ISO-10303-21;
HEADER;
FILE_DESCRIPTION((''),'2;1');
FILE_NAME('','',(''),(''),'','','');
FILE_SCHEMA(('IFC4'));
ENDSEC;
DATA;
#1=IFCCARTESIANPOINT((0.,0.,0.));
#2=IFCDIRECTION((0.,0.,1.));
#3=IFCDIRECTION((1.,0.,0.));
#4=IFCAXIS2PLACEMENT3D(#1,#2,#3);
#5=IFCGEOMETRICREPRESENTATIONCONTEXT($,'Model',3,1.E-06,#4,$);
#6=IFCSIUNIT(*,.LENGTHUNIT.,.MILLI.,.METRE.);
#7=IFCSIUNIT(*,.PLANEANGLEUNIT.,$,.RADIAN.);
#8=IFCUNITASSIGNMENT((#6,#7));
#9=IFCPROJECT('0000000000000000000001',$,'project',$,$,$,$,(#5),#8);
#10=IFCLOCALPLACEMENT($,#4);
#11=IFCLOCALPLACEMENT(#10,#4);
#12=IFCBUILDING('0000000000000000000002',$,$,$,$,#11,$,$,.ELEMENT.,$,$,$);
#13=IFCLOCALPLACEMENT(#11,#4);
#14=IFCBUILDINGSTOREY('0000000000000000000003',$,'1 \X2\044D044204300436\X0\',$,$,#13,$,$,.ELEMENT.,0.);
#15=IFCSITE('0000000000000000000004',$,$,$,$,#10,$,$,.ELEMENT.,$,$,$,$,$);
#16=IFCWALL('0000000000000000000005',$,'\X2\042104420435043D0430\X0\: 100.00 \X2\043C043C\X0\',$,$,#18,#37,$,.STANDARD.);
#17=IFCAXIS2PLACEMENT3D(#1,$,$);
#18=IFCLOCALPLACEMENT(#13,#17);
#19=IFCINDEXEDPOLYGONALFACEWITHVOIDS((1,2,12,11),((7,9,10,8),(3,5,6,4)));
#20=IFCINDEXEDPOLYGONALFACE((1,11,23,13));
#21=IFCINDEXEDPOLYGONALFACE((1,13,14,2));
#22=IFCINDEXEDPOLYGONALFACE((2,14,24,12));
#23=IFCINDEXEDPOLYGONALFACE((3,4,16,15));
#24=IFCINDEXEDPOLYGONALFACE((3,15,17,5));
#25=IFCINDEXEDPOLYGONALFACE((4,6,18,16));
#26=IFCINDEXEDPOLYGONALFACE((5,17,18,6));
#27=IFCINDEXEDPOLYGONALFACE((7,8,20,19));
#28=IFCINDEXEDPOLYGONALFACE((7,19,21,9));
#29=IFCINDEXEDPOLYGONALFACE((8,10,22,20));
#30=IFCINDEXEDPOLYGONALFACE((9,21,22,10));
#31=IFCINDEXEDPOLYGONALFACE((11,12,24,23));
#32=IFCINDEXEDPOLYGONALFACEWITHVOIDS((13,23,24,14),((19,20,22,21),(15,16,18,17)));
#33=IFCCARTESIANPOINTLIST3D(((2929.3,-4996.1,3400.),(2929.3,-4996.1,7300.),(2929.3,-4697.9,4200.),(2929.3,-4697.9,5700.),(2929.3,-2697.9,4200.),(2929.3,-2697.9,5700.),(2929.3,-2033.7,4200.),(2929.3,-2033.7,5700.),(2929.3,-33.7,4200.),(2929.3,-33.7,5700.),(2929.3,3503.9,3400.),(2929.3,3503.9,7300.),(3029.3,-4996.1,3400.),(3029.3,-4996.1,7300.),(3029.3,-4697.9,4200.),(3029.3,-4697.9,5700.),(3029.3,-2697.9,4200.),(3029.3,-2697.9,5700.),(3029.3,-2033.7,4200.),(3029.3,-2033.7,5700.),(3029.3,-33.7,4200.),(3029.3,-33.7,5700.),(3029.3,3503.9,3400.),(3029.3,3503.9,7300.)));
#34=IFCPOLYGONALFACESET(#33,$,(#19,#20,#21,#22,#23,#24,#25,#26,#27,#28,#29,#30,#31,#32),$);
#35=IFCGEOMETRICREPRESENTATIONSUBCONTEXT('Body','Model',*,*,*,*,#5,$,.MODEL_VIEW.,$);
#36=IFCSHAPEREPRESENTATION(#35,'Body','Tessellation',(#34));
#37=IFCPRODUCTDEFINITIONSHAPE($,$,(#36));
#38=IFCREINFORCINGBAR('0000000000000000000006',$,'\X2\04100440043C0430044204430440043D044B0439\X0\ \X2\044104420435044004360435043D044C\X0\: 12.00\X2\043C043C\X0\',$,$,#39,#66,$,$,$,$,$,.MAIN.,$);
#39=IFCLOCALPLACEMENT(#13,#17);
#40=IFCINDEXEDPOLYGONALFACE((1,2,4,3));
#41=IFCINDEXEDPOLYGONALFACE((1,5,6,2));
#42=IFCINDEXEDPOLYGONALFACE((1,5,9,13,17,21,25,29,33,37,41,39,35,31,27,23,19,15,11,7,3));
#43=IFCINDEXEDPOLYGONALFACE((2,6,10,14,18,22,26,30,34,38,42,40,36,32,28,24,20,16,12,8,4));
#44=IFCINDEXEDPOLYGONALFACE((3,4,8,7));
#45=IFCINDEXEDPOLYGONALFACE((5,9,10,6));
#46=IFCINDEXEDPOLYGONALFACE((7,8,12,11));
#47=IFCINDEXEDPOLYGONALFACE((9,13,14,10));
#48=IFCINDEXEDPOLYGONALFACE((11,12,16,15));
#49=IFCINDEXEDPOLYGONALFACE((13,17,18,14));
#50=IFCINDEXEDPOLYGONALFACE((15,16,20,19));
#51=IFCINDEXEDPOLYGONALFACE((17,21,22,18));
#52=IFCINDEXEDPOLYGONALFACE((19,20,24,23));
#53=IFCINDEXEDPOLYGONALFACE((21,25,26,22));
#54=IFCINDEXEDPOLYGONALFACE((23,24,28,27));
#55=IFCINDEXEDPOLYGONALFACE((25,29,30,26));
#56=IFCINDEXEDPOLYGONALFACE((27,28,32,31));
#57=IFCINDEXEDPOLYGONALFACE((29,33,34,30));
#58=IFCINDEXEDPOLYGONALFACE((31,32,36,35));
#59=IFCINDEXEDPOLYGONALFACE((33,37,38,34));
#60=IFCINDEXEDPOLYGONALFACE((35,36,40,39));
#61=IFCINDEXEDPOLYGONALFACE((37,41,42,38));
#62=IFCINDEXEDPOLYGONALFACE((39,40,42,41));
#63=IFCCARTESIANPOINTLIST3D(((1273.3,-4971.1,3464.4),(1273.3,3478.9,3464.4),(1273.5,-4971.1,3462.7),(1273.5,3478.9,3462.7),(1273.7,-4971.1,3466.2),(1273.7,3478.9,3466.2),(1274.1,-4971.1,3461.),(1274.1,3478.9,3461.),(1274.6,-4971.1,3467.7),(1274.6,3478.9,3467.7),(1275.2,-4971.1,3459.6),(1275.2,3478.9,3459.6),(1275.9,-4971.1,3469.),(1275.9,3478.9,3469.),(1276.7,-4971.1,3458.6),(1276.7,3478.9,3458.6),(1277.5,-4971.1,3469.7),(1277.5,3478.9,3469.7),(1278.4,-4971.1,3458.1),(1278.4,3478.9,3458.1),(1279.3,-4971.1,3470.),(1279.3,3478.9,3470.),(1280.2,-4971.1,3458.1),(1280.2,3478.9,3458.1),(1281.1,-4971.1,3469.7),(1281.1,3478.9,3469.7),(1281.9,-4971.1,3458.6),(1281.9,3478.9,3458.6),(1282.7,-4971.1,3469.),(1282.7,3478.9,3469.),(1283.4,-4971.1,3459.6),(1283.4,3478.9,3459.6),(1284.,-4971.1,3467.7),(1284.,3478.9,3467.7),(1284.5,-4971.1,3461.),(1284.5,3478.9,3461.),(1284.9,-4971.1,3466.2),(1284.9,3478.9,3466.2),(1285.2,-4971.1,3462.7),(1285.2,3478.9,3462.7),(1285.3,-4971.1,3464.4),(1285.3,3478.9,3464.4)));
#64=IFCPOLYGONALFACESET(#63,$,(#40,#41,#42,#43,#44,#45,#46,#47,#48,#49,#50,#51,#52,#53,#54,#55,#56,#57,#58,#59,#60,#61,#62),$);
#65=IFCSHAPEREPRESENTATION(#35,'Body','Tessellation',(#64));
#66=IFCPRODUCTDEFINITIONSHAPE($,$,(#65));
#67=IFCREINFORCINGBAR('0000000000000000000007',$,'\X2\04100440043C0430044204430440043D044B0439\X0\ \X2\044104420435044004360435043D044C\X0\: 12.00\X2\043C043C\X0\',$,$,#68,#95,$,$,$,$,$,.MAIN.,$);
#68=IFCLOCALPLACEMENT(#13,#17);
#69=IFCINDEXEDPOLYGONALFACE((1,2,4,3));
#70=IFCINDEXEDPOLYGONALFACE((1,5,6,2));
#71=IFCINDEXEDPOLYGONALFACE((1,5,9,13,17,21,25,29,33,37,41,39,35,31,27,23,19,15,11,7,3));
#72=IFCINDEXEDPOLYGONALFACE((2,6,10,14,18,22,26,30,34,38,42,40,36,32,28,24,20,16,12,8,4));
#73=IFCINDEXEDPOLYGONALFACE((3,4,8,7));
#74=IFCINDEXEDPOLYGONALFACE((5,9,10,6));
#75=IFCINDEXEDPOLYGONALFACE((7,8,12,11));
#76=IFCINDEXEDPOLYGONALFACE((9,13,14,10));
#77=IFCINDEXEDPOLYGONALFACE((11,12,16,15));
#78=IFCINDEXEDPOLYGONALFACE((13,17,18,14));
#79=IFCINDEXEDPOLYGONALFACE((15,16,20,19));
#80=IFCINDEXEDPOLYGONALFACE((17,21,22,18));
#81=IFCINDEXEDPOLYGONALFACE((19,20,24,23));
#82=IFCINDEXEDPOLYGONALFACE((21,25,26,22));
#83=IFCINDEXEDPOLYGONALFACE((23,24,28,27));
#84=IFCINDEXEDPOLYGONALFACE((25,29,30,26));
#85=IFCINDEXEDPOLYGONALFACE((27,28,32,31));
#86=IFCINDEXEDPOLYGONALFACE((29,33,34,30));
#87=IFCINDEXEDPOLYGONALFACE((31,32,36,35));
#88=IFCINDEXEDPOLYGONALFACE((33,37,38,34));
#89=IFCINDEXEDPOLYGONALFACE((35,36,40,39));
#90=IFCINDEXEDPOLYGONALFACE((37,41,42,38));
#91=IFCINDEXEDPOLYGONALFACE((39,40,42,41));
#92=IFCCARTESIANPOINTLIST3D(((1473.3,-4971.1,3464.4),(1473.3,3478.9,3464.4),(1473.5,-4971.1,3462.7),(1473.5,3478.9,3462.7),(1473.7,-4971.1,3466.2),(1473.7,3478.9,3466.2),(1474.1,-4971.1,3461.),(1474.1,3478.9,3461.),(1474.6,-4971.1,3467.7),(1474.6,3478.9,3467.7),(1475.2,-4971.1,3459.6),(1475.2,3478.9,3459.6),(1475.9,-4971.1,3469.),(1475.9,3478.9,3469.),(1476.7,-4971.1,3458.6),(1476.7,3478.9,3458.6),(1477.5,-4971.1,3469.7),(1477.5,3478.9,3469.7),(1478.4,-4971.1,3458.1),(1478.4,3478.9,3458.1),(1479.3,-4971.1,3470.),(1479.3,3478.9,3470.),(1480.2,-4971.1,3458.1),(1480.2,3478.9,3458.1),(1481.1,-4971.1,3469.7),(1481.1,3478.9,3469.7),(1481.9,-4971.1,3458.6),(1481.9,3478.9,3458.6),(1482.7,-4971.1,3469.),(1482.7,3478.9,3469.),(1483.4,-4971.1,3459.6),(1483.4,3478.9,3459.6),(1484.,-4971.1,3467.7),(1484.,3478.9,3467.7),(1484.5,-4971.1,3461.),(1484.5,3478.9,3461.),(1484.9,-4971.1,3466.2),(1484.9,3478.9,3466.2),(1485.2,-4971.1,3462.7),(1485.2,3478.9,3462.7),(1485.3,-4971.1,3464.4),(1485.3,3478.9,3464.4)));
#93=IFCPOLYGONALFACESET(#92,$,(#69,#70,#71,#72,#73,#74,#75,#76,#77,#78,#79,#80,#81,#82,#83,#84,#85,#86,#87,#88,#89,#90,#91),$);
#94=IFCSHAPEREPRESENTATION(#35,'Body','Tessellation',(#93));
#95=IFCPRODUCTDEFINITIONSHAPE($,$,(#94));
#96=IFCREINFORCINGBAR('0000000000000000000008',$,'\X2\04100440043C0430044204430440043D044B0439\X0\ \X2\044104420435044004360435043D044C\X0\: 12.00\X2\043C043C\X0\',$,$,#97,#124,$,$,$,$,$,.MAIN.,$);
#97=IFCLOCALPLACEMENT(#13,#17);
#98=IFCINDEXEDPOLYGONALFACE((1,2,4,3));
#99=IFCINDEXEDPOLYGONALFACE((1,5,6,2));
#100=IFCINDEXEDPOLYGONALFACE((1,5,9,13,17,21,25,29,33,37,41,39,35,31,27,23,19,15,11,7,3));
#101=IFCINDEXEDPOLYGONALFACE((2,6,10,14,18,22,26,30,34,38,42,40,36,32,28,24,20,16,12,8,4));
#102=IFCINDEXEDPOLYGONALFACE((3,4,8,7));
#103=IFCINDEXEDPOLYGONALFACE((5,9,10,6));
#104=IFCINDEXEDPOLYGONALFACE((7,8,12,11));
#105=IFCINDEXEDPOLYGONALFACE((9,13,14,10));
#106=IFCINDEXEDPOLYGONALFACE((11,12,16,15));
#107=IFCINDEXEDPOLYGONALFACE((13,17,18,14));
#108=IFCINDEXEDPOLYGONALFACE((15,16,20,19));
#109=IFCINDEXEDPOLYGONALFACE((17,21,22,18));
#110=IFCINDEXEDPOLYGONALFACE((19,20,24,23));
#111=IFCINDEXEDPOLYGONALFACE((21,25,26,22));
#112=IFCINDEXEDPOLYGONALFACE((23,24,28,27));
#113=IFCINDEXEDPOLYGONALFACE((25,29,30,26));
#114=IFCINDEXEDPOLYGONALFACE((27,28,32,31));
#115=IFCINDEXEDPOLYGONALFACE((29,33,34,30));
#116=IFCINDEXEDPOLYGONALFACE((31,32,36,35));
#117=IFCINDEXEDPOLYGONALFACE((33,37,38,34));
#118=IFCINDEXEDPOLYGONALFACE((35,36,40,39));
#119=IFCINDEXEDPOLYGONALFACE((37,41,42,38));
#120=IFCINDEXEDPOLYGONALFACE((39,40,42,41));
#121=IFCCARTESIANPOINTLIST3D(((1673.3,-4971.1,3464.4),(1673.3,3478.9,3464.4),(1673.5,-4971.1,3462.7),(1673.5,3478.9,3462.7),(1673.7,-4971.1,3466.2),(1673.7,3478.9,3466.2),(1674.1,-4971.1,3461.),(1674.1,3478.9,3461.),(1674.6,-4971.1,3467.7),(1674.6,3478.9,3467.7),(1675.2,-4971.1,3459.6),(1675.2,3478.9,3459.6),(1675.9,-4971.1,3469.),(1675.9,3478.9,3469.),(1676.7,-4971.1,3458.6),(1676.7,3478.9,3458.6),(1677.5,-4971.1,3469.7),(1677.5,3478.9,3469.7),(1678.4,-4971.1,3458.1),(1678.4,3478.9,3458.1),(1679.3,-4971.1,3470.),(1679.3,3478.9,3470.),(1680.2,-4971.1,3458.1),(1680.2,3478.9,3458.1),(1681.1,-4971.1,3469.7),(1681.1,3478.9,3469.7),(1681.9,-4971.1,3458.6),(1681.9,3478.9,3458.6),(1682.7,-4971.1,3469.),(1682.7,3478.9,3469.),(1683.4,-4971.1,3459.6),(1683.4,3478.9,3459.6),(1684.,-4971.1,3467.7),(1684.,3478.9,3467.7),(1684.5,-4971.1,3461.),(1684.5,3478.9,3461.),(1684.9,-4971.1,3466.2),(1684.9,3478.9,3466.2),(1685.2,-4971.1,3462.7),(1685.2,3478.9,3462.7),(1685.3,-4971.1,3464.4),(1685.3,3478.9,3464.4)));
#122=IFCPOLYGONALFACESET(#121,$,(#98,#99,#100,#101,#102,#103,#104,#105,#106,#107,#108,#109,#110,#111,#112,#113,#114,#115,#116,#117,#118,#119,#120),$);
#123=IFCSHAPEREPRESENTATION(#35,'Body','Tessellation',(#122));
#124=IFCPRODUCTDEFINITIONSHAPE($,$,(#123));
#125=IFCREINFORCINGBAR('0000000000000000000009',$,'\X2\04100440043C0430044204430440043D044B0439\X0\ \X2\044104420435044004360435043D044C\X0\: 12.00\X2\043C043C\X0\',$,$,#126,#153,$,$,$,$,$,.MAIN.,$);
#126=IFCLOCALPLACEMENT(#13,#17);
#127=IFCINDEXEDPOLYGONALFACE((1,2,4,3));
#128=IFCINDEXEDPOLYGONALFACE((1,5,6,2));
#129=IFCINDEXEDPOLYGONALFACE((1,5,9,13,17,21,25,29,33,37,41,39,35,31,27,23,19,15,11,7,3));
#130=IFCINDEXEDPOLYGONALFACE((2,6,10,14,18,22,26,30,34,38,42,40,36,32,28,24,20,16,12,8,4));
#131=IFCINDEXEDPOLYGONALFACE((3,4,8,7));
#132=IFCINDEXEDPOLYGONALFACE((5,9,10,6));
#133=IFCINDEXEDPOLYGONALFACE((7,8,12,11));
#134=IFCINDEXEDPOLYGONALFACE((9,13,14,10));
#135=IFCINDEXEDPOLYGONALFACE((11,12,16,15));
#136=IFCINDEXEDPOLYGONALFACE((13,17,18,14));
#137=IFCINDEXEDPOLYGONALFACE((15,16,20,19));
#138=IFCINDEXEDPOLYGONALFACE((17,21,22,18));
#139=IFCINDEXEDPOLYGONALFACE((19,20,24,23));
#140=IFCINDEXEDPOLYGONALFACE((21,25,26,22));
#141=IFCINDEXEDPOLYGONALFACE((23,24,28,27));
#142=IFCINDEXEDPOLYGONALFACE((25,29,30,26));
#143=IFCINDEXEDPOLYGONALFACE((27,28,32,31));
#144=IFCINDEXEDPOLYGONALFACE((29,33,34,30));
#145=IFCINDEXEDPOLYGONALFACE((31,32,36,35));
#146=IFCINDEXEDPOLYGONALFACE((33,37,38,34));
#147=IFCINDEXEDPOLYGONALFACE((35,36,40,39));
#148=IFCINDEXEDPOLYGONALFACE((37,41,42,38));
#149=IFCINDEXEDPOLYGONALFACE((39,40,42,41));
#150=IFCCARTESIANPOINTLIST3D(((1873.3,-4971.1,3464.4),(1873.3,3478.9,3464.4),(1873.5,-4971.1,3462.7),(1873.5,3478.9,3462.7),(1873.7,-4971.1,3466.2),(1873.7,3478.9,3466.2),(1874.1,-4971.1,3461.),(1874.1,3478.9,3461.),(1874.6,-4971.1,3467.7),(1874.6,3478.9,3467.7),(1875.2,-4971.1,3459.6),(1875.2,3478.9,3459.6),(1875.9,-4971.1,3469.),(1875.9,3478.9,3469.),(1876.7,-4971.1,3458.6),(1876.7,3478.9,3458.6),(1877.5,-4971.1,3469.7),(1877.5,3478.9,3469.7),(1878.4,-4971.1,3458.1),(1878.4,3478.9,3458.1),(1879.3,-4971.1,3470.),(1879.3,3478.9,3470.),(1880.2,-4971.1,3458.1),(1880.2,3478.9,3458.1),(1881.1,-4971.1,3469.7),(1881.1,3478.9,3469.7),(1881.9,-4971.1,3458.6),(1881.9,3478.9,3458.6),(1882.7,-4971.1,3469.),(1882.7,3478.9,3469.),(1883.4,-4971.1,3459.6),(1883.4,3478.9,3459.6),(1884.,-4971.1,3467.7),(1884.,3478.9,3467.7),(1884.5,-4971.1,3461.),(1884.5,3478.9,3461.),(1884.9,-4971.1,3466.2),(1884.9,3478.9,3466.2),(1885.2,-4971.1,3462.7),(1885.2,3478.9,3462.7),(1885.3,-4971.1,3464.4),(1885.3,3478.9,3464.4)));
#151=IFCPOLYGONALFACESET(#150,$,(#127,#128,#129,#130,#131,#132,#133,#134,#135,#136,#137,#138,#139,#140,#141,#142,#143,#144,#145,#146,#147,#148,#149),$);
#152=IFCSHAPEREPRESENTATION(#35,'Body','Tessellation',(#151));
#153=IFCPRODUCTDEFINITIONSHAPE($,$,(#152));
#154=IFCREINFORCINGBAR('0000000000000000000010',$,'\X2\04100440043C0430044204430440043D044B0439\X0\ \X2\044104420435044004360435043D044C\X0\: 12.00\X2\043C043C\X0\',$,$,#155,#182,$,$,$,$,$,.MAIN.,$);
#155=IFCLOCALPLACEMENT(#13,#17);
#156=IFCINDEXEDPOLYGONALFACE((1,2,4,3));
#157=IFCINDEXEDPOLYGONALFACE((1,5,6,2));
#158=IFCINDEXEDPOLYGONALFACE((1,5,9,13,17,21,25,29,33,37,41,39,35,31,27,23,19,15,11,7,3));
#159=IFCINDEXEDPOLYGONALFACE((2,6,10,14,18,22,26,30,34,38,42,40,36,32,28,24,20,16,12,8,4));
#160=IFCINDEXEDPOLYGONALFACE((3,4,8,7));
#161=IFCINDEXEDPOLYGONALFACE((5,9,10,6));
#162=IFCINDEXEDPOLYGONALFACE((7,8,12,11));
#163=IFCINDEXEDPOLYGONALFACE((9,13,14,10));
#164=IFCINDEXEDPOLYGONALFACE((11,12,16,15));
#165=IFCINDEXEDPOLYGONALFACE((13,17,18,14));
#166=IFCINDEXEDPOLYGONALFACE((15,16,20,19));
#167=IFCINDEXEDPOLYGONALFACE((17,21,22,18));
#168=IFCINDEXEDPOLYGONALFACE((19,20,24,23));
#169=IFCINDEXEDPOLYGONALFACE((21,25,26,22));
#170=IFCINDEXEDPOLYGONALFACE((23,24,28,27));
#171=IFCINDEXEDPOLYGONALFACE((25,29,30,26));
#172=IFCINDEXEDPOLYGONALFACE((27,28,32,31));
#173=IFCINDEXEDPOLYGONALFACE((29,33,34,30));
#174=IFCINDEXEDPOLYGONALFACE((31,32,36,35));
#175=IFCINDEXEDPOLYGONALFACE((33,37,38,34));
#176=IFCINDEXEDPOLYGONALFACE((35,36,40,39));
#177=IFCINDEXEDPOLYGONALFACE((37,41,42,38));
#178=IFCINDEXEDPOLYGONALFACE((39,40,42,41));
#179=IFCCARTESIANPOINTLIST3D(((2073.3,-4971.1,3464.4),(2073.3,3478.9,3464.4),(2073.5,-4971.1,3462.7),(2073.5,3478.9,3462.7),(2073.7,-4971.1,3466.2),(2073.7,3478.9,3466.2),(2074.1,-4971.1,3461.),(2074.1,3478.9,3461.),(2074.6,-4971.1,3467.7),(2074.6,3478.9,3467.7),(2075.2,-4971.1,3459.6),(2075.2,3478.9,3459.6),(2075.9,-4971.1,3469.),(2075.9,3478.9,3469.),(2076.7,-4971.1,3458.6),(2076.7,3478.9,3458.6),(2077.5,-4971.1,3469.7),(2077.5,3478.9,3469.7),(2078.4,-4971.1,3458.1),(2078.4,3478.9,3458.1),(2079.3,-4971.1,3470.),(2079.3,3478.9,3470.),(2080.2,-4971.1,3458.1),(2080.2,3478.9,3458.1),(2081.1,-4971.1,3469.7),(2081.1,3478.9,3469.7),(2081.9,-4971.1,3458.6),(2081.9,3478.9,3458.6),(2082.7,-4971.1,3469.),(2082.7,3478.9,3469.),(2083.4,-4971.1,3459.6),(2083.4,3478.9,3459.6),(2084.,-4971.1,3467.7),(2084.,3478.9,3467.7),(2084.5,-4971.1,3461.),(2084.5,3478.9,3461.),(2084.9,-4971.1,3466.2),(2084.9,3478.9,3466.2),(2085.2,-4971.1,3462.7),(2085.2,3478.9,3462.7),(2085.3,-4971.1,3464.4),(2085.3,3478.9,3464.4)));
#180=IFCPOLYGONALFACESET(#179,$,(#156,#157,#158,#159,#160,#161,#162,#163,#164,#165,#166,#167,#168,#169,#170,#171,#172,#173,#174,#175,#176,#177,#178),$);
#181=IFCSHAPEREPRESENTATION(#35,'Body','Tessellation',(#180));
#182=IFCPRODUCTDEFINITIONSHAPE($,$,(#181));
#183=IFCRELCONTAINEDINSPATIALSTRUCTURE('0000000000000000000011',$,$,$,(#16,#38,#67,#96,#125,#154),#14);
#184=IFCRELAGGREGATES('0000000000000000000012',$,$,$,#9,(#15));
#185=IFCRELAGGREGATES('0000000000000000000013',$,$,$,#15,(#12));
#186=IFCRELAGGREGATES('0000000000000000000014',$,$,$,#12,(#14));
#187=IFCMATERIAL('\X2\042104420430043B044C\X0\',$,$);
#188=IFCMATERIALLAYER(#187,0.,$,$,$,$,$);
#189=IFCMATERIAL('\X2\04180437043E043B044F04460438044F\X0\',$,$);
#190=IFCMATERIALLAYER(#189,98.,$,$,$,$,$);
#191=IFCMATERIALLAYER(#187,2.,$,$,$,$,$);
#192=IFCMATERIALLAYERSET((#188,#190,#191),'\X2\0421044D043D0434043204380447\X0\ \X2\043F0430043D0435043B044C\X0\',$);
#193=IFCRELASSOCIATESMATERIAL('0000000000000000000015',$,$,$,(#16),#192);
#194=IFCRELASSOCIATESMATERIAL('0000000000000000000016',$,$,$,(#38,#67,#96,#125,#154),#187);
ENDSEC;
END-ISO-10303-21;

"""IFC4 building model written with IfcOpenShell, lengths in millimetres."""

from ifc_helpers import new_model, entity, si_unit, frame, origin_with_axes, place, context, subcontext, project, spatial, line, indexed_curve, outline, extrude, source, transform, mapped, material, layer, layer_set, layer_usage, element, save


model = new_model("IFC4")

# Units and contexts
model_context = context("Model", 3, precision=1e-06, world=origin_with_axes())
body_context = subcontext(model_context, "Body", "Model", "MODEL_VIEW")
ifc_project = project(units=[si_unit("LENGTHUNIT", "METRE", prefix="MILLI"), si_unit("PLANEANGLEUNIT", "RADIAN")], contexts=[model_context])

# Site, building, storey
site_placement = place(None, origin_with_axes())
site = spatial("IfcSite", under=ifc_project, at=site_placement, CompositionType="ELEMENT")
building_placement = place(site_placement, origin_with_axes())
building = spatial("IfcBuilding", under=site, at=building_placement, CompositionType="ELEMENT")
storey_placement = place(building_placement, origin_with_axes())
storey = spatial("IfcBuildingStorey", under=building, at=storey_placement, Name="1 этаж", CompositionType="ELEMENT", Elevation=0.0)

# Wall, openings
ifc_material_1 = material(Name="Сталь")
ifc_layer_1 = layer(ifc_material_1, 0.0)
ifc_material_2 = material(Name="Изоляция")
ifc_layer_2 = layer(ifc_material_2, 98.0)
ifc_layer_3 = layer(ifc_material_1, 2.0)
ifc_layer_set_1 = layer_set([ifc_layer_1, ifc_layer_2, ifc_layer_3], Name="Сэндвич панель")
ifc_layer_usage_1 = layer_usage(ifc_layer_set_1, "AXIS2", "NEGATIVE", 0.0)
wall_placement = place(storey_placement, frame((2929.3, -4996.1, 3400.0), z_axis=(0.0, 0.0, 1.0), x_axis=(0.0, 1.0, 0.0)))
wall = element("IfcWall", 1, at=wall_placement, inside=storey, material=ifc_layer_usage_1, Name="Стена: 100.00 мм", PredefinedType="STANDARD", context=body_context, shape_type="SweptSolid", body=[
    extrude(outline(indexed_curve([(0.0, -100.0), (8500.0, -100.0), (8500.0, 0.0), (0.0, 0.0)], segments=[line(1, 2), line(2, 3), line(3, 4), line(4, 1)])), origin_with_axes(), (0.0, 0.0, 1.0), 3900.0),
])
opening_1_placement = place(wall_placement, frame((2962.4, -100.0, 800.0), z_axis=(0.0, 0.0, 1.0), x_axis=(1.0, 0.0, 0.0)))
element("IfcOpeningElement", 2, at=opening_1_placement, cuts=wall, PredefinedType="OPENING", context=body_context, shape_type="SweptSolid", body=[
    extrude(outline(indexed_curve([(0.0, 0.0), (2000.0, 0.0), (2000.0, 1500.0), (0.0, 1500.0)], segments=[line(1, 2), line(2, 3), line(3, 4), line(4, 1)])), frame((0.0, -5.0, 0.0), z_axis=(0.0, -1.0, 0.0), x_axis=(1.0, 0.0, 0.0)), (0.0, 0.0, -1.0), 110.0),
])
opening_2_placement = place(wall_placement, frame((298.2, -100.0, 800.0), z_axis=(0.0, 0.0, 1.0), x_axis=(1.0, 0.0, 0.0)))
element("IfcOpeningElement", 3, at=opening_2_placement, cuts=wall, PredefinedType="OPENING", context=body_context, shape_type="SweptSolid", body=[
    extrude(outline(indexed_curve([(0.0, 0.0), (2000.0, 0.0), (2000.0, 1500.0), (0.0, 1500.0)], segments=[line(1, 2), line(2, 3), line(3, 4), line(4, 1)])), frame((0.0, -5.0, 0.0), z_axis=(0.0, -1.0, 0.0), x_axis=(1.0, 0.0, 0.0)), (0.0, 0.0, -1.0), 110.0),
])

# Reinforcing bars
shared_shape_1 = source(origin_with_axes(), body_context, "Body", "AdvancedSweptSolid", [
    entity("IfcSweptDiskSolid", entity("IfcIndexedPolyCurve", entity("IfcCartesianPointList3D", [[0.0, 0.0, 0.0], [8450.0, 0.0, 0.0]]), [entity("IfcLineIndex", [1, 2])]), 6.0),
])
reinforcing_bar_1_placement = place(storey_placement, origin_with_axes())
element("IfcReinforcingBar", 4, at=reinforcing_bar_1_placement, inside=storey, material=ifc_material_1, Name="Арматурный стержень: 12.00мм", PredefinedType="MAIN", context=body_context, shape_type="MappedRepresentation", body=[
    mapped(shared_shape_1, transform((1279.3, -4971.1, 3464.0), x_axis=(0.0, 1.0, 0.0), y_axis=(-1.0, 0.0, 0.0), z_axis=(0.0, 0.0, 1.0), scale=1.0)),
])
reinforcing_bar_2_placement = place(storey_placement, origin_with_axes())
element("IfcReinforcingBar", 5, at=reinforcing_bar_2_placement, inside=storey, material=ifc_material_1, Name="Арматурный стержень: 12.00мм", PredefinedType="MAIN", context=body_context, shape_type="MappedRepresentation", body=[
    mapped(shared_shape_1, transform((1479.3, -4971.1, 3464.0), x_axis=(0.0, 1.0, 0.0), y_axis=(-1.0, 0.0, 0.0), z_axis=(0.0, 0.0, 1.0), scale=1.0)),
])
reinforcing_bar_3_placement = place(storey_placement, origin_with_axes())
element("IfcReinforcingBar", 6, at=reinforcing_bar_3_placement, inside=storey, material=ifc_material_1, Name="Арматурный стержень: 12.00мм", PredefinedType="MAIN", context=body_context, shape_type="MappedRepresentation", body=[
    mapped(shared_shape_1, transform((1679.3, -4971.1, 3464.0), x_axis=(0.0, 1.0, 0.0), y_axis=(-1.0, 0.0, 0.0), z_axis=(0.0, 0.0, 1.0), scale=1.0)),
])
reinforcing_bar_4_placement = place(storey_placement, origin_with_axes())
element("IfcReinforcingBar", 7, at=reinforcing_bar_4_placement, inside=storey, material=ifc_material_1, Name="Арматурный стержень: 12.00мм", PredefinedType="MAIN", context=body_context, shape_type="MappedRepresentation", body=[
    mapped(shared_shape_1, transform((1879.3, -4971.1, 3464.0), x_axis=(0.0, 1.0, 0.0), y_axis=(-1.0, 0.0, 0.0), z_axis=(0.0, 0.0, 1.0), scale=1.0)),
])
reinforcing_bar_5_placement = place(storey_placement, origin_with_axes())
element("IfcReinforcingBar", 8, at=reinforcing_bar_5_placement, inside=storey, material=ifc_material_1, Name="Арматурный стержень: 12.00мм", PredefinedType="MAIN", context=body_context, shape_type="MappedRepresentation", body=[
    mapped(shared_shape_1, transform((2079.3, -4971.1, 3464.0), x_axis=(0.0, 1.0, 0.0), y_axis=(-1.0, 0.0, 0.0), z_axis=(0.0, 0.0, 1.0), scale=1.0)),
])

save(model, "model.ifc")
